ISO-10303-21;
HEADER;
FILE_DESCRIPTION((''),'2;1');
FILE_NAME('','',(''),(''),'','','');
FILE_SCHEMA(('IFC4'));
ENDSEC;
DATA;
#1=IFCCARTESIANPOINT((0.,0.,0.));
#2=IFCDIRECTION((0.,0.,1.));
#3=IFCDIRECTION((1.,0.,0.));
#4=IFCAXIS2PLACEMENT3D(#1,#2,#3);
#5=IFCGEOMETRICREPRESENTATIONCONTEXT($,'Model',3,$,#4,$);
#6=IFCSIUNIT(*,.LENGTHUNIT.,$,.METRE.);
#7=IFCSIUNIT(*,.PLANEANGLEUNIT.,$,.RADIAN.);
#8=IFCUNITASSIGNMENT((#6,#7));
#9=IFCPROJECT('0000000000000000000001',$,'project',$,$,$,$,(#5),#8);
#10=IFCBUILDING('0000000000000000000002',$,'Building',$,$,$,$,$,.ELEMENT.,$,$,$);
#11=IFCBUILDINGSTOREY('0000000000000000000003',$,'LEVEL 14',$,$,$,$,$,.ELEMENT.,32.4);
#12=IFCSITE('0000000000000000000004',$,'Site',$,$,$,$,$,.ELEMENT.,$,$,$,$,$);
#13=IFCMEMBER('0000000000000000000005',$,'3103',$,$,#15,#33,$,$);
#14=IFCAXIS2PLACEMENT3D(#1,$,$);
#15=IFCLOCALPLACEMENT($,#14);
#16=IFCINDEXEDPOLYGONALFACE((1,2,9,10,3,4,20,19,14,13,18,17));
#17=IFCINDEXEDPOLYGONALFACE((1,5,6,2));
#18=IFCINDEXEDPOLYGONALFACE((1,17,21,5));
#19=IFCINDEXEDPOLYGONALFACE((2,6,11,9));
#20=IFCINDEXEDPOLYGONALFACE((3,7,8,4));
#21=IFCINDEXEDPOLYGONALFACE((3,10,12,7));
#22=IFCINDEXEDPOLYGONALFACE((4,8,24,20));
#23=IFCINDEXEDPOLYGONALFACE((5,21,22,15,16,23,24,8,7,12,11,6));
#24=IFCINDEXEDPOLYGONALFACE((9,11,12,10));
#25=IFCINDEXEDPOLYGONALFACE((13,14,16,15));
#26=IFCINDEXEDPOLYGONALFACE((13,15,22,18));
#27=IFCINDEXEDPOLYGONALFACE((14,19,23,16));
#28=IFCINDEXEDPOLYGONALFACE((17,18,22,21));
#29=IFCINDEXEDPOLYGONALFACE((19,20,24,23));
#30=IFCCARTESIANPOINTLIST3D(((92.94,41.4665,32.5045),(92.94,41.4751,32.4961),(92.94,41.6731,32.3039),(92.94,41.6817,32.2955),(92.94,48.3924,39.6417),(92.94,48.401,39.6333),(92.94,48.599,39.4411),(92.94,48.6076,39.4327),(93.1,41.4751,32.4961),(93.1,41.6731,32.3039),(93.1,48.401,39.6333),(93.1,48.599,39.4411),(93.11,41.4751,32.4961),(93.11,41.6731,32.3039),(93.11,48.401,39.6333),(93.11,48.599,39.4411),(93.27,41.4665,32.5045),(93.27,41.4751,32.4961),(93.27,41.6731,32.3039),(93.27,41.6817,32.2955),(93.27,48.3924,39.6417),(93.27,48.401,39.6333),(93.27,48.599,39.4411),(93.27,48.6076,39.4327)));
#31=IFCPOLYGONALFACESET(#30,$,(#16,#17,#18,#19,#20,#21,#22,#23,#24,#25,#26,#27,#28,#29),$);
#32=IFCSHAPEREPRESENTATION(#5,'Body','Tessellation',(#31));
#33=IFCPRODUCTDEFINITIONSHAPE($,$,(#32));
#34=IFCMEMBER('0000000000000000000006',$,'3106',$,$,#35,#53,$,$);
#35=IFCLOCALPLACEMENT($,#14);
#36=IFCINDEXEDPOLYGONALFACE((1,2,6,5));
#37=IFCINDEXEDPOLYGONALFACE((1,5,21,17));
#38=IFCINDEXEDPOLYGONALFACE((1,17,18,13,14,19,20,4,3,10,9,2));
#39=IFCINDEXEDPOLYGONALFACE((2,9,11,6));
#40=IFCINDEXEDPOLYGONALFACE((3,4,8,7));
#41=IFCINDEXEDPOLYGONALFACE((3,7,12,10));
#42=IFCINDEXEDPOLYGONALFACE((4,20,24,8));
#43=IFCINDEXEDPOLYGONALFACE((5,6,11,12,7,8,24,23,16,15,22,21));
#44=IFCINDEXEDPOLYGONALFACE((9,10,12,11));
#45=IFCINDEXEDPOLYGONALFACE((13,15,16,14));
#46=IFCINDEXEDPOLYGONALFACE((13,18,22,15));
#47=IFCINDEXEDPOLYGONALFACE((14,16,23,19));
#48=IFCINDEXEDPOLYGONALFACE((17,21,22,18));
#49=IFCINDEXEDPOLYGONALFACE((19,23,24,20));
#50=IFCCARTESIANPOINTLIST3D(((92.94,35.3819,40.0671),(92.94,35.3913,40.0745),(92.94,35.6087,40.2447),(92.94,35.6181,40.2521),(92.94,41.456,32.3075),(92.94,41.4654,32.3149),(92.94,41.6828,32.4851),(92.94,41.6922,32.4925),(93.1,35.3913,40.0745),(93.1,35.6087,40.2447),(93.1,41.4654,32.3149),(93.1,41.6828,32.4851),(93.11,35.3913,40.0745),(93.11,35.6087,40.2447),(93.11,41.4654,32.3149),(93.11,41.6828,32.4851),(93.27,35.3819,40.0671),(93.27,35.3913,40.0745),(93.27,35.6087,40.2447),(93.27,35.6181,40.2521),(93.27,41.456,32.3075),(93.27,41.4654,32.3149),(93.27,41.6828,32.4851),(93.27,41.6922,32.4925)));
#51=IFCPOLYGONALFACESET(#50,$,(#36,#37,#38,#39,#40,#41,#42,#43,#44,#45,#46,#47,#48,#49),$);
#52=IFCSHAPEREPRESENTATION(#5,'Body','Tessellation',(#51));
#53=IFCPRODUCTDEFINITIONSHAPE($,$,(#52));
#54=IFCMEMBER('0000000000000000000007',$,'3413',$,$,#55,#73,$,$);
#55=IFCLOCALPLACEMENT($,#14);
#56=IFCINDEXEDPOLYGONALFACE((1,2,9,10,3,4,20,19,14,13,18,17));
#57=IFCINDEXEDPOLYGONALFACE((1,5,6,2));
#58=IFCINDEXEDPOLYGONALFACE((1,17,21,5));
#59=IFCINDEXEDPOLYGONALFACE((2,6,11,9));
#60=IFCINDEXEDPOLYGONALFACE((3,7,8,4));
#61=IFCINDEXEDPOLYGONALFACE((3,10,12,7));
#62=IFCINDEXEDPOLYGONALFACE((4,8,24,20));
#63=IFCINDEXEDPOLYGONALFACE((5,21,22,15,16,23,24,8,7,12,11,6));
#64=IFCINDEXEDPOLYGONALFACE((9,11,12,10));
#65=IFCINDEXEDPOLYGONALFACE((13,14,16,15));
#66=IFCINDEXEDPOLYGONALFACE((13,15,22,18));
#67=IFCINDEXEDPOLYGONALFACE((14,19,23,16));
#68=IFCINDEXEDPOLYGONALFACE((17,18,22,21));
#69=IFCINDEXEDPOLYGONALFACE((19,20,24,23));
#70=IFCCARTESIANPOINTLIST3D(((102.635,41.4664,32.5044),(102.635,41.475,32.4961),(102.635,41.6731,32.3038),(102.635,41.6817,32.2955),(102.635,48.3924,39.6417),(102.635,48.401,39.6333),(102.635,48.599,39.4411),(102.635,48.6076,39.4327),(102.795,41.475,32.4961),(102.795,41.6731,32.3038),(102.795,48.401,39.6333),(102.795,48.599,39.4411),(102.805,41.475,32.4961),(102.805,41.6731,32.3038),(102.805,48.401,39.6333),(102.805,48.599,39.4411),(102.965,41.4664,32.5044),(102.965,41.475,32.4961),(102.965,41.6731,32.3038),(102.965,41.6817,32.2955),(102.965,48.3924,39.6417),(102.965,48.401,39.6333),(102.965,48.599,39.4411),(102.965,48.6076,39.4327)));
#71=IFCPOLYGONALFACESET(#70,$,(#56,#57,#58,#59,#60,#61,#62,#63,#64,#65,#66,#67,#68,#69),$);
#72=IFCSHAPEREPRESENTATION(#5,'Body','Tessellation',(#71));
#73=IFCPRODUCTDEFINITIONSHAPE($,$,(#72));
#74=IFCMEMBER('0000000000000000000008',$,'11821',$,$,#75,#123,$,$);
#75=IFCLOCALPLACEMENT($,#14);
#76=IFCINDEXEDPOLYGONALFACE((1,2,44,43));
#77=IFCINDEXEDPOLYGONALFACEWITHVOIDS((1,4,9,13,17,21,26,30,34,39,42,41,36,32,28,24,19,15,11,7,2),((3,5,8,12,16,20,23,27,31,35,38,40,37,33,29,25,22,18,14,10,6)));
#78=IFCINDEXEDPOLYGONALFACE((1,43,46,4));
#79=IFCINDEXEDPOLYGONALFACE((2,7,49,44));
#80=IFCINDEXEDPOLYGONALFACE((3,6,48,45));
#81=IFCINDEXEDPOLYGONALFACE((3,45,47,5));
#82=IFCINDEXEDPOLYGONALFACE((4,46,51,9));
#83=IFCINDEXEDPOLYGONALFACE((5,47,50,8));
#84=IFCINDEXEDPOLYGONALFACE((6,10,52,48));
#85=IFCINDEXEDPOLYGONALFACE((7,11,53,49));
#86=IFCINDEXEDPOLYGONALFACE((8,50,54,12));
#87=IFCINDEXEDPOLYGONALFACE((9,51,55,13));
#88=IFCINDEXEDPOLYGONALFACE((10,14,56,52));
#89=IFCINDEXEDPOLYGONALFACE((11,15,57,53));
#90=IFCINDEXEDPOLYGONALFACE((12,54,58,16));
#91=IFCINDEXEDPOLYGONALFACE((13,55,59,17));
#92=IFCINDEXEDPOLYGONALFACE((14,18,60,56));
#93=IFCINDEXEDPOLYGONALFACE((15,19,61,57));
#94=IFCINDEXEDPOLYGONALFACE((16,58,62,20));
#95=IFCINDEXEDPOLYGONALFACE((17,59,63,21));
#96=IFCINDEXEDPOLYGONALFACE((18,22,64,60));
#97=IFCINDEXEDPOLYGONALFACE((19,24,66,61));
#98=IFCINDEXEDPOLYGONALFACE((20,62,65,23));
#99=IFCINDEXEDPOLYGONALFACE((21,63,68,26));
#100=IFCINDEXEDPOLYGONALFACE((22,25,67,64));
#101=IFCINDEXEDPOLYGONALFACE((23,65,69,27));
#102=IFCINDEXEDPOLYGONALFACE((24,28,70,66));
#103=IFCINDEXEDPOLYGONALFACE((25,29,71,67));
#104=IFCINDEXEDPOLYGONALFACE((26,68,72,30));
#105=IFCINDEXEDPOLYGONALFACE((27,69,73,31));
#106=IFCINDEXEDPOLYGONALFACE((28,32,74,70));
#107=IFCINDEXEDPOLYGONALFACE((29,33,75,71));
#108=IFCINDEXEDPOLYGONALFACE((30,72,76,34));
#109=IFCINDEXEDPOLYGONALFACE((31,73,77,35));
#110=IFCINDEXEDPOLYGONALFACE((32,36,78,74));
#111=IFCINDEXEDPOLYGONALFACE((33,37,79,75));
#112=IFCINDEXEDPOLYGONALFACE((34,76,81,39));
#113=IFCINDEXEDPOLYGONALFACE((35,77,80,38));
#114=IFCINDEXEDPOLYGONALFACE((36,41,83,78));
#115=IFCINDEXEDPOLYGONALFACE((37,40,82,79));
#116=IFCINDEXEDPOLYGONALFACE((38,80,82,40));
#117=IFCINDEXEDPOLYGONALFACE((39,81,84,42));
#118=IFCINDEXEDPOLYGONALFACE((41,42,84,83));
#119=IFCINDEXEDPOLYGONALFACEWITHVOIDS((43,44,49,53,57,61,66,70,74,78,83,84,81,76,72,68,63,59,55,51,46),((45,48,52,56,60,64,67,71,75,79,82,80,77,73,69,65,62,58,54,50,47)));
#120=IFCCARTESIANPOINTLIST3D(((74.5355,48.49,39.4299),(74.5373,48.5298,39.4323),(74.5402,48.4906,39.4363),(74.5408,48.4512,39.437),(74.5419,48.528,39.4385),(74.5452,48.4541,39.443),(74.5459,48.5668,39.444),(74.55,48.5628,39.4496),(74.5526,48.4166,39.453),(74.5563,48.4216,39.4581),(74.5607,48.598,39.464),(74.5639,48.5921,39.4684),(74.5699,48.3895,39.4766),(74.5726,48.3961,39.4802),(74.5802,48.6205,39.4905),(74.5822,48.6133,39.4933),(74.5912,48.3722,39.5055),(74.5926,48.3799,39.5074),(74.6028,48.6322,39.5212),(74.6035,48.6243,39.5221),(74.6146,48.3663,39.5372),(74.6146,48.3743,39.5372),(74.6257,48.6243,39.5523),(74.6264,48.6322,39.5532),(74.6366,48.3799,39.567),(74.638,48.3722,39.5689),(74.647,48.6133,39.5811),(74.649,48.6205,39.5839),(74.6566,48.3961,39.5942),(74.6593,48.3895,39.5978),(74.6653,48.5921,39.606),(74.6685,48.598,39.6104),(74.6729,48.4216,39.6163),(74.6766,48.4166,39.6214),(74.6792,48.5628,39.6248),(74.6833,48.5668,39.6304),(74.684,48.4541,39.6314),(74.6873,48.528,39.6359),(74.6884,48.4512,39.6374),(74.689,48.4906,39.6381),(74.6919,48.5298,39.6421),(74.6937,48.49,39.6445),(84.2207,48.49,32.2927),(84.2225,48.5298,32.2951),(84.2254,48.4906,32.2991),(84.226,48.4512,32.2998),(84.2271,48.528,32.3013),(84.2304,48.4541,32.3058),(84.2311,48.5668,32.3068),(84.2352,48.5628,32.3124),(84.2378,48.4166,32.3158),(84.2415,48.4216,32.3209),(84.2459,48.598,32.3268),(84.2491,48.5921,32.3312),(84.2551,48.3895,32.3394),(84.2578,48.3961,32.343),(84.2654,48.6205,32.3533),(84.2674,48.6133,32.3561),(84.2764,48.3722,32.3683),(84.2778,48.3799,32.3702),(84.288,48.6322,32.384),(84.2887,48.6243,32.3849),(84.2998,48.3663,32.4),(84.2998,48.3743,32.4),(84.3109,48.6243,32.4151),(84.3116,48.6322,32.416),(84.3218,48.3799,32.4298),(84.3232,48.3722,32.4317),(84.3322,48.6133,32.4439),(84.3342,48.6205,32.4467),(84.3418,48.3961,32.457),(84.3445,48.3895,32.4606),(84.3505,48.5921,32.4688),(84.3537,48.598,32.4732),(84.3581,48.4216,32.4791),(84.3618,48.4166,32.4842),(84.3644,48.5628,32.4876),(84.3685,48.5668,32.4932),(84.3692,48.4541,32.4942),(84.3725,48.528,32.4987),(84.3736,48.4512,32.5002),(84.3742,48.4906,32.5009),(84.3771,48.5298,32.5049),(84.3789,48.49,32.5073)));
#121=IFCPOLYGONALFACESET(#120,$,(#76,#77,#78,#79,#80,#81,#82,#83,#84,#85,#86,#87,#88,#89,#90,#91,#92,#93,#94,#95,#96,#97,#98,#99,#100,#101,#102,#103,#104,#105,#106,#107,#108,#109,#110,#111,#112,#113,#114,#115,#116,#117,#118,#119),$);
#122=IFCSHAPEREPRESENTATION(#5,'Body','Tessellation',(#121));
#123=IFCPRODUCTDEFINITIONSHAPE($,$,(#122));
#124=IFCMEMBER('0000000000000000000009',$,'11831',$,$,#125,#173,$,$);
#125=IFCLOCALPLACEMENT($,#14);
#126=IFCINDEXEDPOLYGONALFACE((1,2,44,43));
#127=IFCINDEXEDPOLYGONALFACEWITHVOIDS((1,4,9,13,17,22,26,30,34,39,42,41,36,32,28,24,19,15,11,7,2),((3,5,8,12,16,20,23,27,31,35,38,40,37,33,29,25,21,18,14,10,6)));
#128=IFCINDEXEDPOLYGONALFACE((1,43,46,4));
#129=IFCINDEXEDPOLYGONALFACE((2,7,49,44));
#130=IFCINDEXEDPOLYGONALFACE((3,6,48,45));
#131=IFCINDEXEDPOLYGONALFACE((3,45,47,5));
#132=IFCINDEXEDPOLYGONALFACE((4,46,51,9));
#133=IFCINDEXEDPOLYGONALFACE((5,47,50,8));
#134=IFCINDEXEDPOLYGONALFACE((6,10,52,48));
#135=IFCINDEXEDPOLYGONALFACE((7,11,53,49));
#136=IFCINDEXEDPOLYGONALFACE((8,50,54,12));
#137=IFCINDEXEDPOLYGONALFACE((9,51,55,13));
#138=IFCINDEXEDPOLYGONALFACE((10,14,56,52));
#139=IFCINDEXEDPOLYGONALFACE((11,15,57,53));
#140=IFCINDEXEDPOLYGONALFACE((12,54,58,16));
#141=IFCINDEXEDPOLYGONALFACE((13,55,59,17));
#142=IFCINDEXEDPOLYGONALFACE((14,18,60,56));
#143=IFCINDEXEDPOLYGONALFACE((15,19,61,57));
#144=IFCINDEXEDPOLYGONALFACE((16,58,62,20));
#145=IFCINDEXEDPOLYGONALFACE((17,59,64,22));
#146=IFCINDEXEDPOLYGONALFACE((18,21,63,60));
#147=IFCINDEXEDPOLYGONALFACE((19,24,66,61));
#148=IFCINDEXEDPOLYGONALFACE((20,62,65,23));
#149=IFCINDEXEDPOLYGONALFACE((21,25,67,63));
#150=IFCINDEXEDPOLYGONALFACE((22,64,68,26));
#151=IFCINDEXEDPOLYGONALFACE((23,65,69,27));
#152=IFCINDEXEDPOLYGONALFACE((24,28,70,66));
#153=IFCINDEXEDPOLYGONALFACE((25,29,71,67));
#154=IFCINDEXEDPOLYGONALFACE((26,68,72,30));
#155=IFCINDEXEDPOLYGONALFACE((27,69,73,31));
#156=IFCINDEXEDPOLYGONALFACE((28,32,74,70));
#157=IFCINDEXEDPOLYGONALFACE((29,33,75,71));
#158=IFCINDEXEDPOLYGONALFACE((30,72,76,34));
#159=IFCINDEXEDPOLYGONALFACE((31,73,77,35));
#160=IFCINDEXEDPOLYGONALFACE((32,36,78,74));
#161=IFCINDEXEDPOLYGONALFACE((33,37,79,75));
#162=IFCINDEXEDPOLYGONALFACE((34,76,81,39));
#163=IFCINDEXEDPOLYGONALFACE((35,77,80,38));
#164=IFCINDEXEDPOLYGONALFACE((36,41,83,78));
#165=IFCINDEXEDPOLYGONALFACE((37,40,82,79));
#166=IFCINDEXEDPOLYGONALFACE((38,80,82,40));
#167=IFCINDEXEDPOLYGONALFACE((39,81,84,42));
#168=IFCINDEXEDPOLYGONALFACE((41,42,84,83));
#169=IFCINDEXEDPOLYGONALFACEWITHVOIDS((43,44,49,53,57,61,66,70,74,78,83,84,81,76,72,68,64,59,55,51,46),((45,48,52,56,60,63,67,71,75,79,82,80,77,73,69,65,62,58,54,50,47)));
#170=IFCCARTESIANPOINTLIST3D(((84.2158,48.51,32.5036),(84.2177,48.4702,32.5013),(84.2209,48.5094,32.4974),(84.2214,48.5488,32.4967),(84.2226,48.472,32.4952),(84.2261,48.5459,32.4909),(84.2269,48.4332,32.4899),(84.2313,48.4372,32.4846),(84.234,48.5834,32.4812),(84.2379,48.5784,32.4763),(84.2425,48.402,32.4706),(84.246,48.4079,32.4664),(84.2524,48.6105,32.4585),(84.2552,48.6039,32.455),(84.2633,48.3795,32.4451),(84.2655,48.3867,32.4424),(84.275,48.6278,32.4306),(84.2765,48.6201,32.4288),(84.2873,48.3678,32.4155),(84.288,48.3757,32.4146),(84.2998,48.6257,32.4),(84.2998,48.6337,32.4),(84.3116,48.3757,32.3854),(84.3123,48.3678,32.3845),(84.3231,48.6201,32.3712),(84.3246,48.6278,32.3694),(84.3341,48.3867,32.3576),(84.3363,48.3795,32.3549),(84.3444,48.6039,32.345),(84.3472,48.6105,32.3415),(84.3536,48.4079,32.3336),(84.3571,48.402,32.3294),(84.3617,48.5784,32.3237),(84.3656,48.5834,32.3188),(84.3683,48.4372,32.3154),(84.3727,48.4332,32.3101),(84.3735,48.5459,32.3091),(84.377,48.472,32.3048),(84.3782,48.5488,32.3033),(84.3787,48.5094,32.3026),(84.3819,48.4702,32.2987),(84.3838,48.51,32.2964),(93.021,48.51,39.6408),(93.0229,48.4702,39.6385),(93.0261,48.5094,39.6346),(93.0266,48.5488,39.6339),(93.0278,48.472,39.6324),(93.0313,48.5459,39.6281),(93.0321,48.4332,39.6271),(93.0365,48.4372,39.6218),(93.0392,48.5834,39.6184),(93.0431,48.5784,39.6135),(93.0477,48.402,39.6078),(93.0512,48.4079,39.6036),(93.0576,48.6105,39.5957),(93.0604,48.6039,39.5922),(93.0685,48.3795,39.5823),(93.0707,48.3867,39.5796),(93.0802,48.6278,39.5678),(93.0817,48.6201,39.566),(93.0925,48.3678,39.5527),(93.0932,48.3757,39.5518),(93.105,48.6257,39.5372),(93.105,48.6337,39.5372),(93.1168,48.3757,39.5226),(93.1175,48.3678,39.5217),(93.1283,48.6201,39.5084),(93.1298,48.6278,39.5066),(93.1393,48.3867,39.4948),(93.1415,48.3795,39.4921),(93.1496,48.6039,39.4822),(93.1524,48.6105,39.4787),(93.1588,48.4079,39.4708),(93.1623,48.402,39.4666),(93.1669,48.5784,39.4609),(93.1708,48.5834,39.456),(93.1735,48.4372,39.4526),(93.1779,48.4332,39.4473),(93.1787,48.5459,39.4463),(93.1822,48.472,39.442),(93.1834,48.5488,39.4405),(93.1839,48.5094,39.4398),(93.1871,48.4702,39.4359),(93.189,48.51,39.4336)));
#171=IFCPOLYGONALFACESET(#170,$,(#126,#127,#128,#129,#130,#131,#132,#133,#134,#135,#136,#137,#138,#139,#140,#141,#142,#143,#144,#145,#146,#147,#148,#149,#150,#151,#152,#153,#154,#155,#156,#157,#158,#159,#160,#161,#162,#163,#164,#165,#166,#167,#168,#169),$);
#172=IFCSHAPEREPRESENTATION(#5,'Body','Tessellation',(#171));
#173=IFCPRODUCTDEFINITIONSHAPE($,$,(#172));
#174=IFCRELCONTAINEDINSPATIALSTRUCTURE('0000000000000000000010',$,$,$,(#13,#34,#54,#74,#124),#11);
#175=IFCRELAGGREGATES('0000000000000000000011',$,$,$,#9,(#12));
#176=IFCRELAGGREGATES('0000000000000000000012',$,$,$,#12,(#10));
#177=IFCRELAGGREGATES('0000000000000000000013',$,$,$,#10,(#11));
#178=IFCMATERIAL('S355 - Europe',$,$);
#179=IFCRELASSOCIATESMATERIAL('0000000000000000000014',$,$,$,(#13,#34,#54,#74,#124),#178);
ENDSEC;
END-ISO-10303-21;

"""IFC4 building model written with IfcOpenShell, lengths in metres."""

from ifc_helpers import new_model, si_unit, frame, origin_with_axes, origin_2d_with_axis, place, context, project, spatial, hollow_circle, i_section, extrude, material, material_profile, profile_set, profile_usage, element, save


model = new_model("IFC4")

# Units and contexts
model_context = context("Model", 3, world=origin_with_axes())
ifc_project = project(units=[si_unit("LENGTHUNIT", "METRE"), si_unit("PLANEANGLEUNIT", "RADIAN")], contexts=[model_context])

# Site, building, storey
site = spatial("IfcSite", under=ifc_project, Name="Site", CompositionType="ELEMENT")
building = spatial("IfcBuilding", under=site, Name="Building", CompositionType="ELEMENT")
storey = spatial("IfcBuildingStorey", under=building, Name="LEVEL 14", CompositionType="ELEMENT", Elevation=32.4)

# Shared definitions
ifc_material = material(Name="S355 - Europe")

# Members
ifc_material_profile_1 = material_profile(ifc_material, i_section(OverallWidth=0.33, OverallDepth=0.3, WebThickness=0.01, FlangeThickness=0.012, at=origin_2d_with_axis()))
ifc_profile_set_1 = profile_set([ifc_material_profile_1])
ifc_profile_usage_1 = profile_usage(ifc_profile_set_1, cardinal=10)
member_1_placement = place(None, frame((93.105, 41.5741, 32.4), z_axis=(0.0, 0.696404, 0.71765), x_axis=(-1.0, 0.0, 0.0)))
element("IfcMember", 1, at=member_1_placement, inside=storey, material=ifc_profile_usage_1, Name="3103", context=model_context, shape_type="SweptSolid", body=[
    extrude(i_section(OverallWidth=0.33, OverallDepth=0.3, WebThickness=0.01, FlangeThickness=0.012, at=origin_2d_with_axis()), origin_with_axes(), (0.0, 0.0, 1.0), 9.9452),
])
ifc_material_profile_2 = material_profile(ifc_material, i_section(OverallWidth=0.33, OverallDepth=0.3, WebThickness=0.01, FlangeThickness=0.012, at=origin_2d_with_axis()))
ifc_profile_set_2 = profile_set([ifc_material_profile_2])
ifc_profile_usage_2 = profile_usage(ifc_profile_set_2, cardinal=10)
member_2_placement = place(None, frame((93.105, 41.5741, 32.4), z_axis=(0.0, -0.616394, 0.787438), x_axis=(1.0, 0.0, 0.0)))
element("IfcMember", 2, at=member_2_placement, inside=storey, material=ifc_profile_usage_2, Name="3106", context=model_context, shape_type="SweptSolid", body=[
    extrude(i_section(OverallWidth=0.33, OverallDepth=0.3, WebThickness=0.01, FlangeThickness=0.012, at=origin_2d_with_axis()), origin_with_axes(), (0.0, 0.0, 1.0), 9.8542),
])
ifc_material_profile_3 = material_profile(ifc_material, i_section(OverallWidth=0.33, OverallDepth=0.3, WebThickness=0.01, FlangeThickness=0.012, at=origin_2d_with_axis()))
ifc_profile_set_3 = profile_set([ifc_material_profile_3])
ifc_profile_usage_3 = profile_usage(ifc_profile_set_3, cardinal=10)
member_3_placement = place(None, frame((102.8, 48.5, 39.5372), z_axis=(0.0, -0.696404, -0.71765), x_axis=(1.0, 0.0, 0.0)))
element("IfcMember", 3, at=member_3_placement, inside=storey, material=ifc_profile_usage_3, Name="3413", context=model_context, shape_type="SweptSolid", body=[
    extrude(i_section(OverallWidth=0.33, OverallDepth=0.3, WebThickness=0.01, FlangeThickness=0.012, at=origin_2d_with_axis()), origin_with_axes(), (0.0, 0.0, 1.0), 9.9453),
])
ifc_material_profile_4 = material_profile(ifc_material, hollow_circle(Radius=0.1337, WallThickness=0.008, at=origin_2d_with_axis()))
ifc_profile_set_4 = profile_set([ifc_material_profile_4])
ifc_profile_usage_4 = profile_usage(ifc_profile_set_4, cardinal=10)
member_4_placement = place(None, frame((84.2998, 48.5, 32.4), z_axis=(-0.805027, 0.0, 0.593239), x_axis=(0.0, -1.0, 0.0)))
element("IfcMember", 4, at=member_4_placement, inside=storey, material=ifc_profile_usage_4, Name="11821", context=model_context, shape_type="SweptSolid", body=[
    extrude(hollow_circle(Radius=0.1337, WallThickness=0.008, at=origin_2d_with_axis()), origin_with_axes(), (0.0, 0.0, 1.0), 12.0309),
])
ifc_material_profile_5 = material_profile(ifc_material, hollow_circle(Radius=0.1337, WallThickness=0.008, at=origin_2d_with_axis()))
ifc_profile_set_5 = profile_set([ifc_material_profile_5])
ifc_profile_usage_5 = profile_usage(ifc_profile_set_5, cardinal=10)
member_5_placement = place(None, frame((84.2998, 48.5, 32.4), z_axis=(0.776849, 0.0, 0.629687), x_axis=(0.0, 1.0, 0.0)))
element("IfcMember", 5, at=member_5_placement, inside=storey, material=ifc_profile_usage_5, Name="11831", context=model_context, shape_type="SweptSolid", body=[
    extrude(hollow_circle(Radius=0.1337, WallThickness=0.008, at=origin_2d_with_axis()), origin_with_axes(), (0.0, 0.0, 1.0), 11.3345),
])

save(model, "model.ifc")
